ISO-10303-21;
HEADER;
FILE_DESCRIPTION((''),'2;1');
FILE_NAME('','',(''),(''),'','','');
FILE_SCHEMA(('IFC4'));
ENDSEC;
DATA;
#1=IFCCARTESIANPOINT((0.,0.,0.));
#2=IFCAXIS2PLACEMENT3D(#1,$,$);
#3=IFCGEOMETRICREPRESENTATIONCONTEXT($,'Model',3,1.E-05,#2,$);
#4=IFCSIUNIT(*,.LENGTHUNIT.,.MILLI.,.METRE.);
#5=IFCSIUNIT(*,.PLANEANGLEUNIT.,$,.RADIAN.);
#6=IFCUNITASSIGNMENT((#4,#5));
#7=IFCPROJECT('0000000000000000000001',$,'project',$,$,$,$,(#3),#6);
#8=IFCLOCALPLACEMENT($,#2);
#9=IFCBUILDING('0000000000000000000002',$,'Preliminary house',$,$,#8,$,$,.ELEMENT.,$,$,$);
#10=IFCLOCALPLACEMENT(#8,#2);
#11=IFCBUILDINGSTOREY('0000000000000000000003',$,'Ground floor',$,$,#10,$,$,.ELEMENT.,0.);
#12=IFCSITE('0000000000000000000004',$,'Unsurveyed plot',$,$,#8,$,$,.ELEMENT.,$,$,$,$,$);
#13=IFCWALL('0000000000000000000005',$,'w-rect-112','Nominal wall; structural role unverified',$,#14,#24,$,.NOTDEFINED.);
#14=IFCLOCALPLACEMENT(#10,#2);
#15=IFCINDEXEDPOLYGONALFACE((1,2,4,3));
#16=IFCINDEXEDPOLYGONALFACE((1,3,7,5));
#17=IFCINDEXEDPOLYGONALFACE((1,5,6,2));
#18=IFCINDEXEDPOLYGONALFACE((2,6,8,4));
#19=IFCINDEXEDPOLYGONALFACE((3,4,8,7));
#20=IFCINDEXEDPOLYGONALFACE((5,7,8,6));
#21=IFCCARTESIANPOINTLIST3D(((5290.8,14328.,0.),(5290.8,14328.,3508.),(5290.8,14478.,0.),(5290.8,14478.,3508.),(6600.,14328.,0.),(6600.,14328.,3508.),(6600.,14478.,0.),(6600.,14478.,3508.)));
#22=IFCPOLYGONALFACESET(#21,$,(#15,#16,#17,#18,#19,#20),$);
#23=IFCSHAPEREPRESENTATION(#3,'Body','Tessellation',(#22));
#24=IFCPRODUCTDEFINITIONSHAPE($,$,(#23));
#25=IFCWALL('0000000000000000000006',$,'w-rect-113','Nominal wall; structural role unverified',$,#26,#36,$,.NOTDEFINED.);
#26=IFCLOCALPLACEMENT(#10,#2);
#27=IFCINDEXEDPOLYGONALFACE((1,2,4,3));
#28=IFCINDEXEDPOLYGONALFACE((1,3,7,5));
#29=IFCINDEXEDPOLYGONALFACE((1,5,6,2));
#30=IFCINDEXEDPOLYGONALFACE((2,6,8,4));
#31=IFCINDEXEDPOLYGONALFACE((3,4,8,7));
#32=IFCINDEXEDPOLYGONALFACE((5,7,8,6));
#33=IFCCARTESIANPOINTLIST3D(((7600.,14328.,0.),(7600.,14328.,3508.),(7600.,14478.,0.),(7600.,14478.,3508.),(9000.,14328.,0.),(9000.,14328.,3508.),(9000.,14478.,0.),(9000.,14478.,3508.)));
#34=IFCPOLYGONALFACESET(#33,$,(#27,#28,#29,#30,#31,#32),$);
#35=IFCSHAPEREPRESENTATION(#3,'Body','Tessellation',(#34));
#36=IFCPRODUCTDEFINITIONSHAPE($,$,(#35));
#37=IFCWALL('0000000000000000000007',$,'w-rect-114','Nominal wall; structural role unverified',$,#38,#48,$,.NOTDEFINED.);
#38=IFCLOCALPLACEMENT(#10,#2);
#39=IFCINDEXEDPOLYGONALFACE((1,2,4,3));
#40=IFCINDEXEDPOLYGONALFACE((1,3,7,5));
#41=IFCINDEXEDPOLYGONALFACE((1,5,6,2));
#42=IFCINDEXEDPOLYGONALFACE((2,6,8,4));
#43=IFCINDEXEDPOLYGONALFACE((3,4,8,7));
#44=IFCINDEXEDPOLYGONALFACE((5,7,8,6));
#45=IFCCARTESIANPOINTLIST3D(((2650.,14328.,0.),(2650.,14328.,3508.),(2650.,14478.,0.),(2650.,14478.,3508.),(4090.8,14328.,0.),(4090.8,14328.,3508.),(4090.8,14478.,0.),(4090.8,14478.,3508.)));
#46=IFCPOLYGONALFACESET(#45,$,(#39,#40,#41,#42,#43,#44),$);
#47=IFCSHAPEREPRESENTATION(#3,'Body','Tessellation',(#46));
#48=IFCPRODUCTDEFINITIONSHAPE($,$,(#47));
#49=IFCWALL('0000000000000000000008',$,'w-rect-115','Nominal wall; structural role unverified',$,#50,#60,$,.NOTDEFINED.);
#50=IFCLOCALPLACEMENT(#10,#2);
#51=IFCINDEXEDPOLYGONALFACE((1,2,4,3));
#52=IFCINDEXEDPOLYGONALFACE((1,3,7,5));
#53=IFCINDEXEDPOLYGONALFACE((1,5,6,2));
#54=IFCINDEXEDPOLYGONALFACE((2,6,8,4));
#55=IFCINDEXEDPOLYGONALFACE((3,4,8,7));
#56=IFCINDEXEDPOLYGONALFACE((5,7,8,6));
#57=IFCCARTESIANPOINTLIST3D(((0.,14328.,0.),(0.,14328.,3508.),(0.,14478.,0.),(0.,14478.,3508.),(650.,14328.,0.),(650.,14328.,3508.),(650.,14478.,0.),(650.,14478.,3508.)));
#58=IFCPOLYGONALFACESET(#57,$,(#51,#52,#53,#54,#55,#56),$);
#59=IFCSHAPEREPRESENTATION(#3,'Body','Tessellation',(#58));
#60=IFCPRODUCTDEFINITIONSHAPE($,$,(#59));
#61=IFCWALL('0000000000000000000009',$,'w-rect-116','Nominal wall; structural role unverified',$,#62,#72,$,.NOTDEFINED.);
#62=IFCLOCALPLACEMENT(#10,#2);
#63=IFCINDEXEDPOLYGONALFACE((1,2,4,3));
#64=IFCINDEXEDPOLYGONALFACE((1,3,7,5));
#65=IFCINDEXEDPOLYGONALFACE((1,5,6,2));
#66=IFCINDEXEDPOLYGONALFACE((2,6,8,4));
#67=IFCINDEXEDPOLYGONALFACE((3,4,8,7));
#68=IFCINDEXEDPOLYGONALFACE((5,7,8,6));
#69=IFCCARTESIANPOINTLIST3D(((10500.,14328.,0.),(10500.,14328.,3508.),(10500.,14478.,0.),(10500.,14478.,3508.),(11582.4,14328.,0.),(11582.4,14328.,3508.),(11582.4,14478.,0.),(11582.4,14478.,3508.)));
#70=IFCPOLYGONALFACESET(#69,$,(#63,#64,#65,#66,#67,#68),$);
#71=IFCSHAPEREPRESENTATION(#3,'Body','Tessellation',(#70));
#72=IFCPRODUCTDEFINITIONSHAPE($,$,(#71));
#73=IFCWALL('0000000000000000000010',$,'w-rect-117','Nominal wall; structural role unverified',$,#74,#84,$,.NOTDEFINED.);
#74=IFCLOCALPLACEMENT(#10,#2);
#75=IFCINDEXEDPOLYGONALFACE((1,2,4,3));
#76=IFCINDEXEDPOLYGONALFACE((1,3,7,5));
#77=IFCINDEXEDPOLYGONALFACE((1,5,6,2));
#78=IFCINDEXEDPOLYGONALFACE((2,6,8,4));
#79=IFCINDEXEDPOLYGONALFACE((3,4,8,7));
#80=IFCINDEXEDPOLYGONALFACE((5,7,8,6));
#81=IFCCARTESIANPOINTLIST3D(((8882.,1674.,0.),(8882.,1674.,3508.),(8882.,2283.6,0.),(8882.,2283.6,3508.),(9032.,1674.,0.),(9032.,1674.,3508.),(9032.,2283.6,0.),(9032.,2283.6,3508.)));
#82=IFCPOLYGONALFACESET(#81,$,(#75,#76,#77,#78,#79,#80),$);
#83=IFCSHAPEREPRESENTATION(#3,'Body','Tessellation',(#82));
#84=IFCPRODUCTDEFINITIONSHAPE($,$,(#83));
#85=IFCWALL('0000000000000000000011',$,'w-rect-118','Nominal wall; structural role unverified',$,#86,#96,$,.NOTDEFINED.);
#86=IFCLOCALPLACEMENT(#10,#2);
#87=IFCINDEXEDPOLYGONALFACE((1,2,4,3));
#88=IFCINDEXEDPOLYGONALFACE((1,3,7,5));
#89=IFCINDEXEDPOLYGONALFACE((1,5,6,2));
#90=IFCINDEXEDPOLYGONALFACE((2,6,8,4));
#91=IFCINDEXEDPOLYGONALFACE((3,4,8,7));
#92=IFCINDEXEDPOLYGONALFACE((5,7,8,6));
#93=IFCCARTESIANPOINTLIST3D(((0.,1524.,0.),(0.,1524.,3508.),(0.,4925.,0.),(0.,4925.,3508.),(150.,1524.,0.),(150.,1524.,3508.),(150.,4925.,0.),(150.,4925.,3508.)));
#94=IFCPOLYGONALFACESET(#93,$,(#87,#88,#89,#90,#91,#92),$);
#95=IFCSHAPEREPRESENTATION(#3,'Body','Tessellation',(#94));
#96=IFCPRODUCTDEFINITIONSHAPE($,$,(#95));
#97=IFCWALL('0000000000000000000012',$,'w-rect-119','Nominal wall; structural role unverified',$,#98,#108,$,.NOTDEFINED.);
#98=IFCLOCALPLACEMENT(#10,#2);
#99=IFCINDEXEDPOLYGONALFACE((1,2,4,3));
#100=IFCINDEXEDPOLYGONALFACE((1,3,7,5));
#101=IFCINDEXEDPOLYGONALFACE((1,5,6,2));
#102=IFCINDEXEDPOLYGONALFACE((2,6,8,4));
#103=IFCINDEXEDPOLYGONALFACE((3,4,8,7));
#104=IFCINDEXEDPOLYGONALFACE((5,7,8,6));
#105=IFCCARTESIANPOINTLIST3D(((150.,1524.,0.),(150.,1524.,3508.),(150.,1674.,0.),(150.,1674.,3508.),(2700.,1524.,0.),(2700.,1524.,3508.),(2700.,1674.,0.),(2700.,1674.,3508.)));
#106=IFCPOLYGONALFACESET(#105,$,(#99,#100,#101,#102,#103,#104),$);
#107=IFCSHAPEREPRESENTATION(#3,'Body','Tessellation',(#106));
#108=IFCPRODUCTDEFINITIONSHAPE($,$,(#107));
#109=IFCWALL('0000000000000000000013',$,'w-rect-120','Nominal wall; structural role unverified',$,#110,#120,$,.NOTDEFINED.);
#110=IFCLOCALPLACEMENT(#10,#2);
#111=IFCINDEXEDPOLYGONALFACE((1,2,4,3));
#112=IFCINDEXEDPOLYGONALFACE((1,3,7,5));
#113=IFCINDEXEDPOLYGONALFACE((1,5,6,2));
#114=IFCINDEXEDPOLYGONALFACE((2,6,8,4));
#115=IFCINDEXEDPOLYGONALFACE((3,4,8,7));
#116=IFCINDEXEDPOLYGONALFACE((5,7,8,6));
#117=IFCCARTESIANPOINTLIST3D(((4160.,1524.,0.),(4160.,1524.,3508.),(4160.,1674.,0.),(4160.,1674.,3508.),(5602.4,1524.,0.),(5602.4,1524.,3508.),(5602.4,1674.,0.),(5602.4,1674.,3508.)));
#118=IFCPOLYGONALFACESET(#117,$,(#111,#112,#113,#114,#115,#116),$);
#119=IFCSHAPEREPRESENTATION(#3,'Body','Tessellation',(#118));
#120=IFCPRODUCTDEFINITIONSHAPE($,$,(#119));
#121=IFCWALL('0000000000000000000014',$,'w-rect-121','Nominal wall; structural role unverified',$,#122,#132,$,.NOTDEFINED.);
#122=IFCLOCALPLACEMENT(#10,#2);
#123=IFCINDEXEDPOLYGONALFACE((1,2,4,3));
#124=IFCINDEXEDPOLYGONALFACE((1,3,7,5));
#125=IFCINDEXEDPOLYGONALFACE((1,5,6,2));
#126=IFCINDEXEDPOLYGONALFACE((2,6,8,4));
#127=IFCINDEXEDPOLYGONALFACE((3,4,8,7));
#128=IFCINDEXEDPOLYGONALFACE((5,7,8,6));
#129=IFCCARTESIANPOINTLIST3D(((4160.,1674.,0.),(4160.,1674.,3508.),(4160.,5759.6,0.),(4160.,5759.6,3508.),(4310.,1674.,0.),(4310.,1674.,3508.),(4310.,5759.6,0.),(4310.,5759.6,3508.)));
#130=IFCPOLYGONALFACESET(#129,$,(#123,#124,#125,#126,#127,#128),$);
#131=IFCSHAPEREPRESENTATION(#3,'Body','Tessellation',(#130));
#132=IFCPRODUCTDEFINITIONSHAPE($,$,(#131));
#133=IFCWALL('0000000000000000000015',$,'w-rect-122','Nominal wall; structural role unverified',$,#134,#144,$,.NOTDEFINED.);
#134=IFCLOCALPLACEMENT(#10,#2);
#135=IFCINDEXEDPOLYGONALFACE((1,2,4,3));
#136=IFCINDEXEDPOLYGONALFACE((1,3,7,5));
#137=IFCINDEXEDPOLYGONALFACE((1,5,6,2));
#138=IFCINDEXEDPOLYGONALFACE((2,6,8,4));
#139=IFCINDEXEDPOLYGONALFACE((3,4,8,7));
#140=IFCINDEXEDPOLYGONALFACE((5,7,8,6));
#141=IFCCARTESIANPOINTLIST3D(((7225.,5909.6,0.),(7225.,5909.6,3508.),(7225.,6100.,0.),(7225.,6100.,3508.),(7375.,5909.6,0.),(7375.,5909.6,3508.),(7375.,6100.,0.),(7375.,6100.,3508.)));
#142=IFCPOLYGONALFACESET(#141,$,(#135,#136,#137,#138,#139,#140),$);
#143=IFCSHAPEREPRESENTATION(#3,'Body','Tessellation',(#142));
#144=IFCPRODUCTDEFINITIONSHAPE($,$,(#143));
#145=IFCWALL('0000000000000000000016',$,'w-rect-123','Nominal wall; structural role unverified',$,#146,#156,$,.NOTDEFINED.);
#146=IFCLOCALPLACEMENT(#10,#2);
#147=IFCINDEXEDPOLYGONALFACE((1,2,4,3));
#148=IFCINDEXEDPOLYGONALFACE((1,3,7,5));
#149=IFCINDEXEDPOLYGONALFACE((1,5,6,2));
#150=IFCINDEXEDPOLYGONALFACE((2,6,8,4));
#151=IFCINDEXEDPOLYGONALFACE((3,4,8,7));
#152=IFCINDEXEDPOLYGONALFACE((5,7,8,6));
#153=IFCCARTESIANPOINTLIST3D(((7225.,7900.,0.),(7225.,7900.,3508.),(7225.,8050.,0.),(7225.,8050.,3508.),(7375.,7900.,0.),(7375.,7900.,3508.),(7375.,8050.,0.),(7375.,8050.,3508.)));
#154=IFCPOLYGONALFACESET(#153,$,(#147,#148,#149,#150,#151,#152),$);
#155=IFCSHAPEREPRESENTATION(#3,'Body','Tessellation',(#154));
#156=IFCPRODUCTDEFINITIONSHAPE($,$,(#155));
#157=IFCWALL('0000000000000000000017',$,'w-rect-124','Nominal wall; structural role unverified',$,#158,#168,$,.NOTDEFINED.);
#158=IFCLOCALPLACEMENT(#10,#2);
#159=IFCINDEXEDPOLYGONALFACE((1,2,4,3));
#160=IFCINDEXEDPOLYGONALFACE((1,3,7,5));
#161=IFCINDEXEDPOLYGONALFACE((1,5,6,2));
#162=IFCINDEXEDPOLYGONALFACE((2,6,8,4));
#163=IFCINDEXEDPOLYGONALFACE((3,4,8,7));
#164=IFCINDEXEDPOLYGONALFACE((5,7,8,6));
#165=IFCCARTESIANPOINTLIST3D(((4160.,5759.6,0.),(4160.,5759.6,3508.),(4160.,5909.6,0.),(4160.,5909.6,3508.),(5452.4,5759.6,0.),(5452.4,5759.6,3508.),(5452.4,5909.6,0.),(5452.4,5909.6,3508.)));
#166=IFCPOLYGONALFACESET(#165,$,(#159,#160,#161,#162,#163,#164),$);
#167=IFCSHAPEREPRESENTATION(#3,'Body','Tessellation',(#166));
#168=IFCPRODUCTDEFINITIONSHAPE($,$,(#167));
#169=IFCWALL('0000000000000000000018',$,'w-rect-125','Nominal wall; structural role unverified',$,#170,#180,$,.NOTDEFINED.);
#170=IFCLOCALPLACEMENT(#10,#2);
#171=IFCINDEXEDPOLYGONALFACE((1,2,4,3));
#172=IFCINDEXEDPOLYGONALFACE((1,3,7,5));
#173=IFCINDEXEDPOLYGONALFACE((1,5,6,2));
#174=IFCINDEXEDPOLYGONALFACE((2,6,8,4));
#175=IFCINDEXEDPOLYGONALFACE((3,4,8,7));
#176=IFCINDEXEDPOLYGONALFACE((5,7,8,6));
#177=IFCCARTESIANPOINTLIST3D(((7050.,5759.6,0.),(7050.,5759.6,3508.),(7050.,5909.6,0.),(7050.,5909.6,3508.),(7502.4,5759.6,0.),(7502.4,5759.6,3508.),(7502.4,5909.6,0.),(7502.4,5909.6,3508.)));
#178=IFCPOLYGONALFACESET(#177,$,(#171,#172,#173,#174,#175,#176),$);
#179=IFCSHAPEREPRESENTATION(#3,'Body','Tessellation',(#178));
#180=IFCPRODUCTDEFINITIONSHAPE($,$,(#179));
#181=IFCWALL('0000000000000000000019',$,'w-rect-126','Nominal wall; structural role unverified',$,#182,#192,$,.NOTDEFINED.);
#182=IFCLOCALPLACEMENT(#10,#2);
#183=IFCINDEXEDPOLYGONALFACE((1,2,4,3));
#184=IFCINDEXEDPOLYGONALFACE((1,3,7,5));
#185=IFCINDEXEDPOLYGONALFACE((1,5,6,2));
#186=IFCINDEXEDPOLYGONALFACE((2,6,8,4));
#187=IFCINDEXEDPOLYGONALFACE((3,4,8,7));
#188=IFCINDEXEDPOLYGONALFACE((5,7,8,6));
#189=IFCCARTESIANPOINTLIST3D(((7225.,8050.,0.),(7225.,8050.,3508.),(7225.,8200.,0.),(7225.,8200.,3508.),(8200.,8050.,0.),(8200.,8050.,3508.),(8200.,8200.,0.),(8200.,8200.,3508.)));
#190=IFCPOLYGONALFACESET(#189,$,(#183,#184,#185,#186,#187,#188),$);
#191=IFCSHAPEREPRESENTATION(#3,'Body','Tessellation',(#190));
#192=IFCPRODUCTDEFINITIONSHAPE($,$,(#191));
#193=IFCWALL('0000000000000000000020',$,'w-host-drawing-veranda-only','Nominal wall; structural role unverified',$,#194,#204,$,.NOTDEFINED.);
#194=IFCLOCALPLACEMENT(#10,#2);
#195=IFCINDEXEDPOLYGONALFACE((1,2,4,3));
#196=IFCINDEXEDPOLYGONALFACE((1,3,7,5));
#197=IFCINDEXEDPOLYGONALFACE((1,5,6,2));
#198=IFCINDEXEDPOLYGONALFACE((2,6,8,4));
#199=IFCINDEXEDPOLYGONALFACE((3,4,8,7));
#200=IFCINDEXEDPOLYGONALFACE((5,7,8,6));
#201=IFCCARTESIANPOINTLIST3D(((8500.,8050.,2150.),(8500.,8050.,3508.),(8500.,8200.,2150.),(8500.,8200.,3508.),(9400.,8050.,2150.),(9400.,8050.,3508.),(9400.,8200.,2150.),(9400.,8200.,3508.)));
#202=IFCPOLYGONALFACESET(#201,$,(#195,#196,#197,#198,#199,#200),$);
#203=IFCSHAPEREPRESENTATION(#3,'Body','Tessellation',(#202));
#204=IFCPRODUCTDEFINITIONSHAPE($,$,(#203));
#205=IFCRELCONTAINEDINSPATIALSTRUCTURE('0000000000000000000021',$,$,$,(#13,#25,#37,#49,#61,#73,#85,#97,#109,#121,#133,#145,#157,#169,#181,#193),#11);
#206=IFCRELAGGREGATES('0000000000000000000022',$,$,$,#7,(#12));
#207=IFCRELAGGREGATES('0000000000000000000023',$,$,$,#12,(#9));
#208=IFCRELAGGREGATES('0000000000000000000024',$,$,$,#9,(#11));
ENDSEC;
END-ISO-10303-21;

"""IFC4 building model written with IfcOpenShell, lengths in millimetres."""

from ifc_helpers import new_model, si_unit, origin, place, context, project, spatial, polyline, outline, extrude, element, save


model = new_model("IFC4")

# Units and contexts
model_context = context("Model", 3, precision=1e-05, world=origin())
ifc_project = project(units=[si_unit("LENGTHUNIT", "METRE", prefix="MILLI"), si_unit("PLANEANGLEUNIT", "RADIAN")], contexts=[model_context])

# Site, building, storey
placement_1 = place(None, origin())
site = spatial("IfcSite", under=ifc_project, at=placement_1, Name="Unsurveyed plot", CompositionType="ELEMENT")
building = spatial("IfcBuilding", under=site, at=placement_1, Name="Preliminary house", CompositionType="ELEMENT")
placement_2 = place(placement_1, origin())
storey = spatial("IfcBuildingStorey", under=building, at=placement_2, Name="Ground floor", CompositionType="ELEMENT", Elevation=0.0)

# Walls
element("IfcWall", 1, at=placement_2, inside=storey, Name="w-rect-112", Description="Nominal wall; structural role unverified", PredefinedType="NOTDEFINED", context=model_context, shape_type="SweptSolid", body=[
    extrude(outline(polyline([(5290.8, 14328.0), (6600.0, 14328.0), (6600.0, 14478.0), (5290.8, 14478.0), (5290.8, 14328.0)])), origin(), (0.0, 0.0, 1.0), 3508.0),
])
element("IfcWall", 2, at=placement_2, inside=storey, Name="w-rect-113", Description="Nominal wall; structural role unverified", PredefinedType="NOTDEFINED", context=model_context, shape_type="SweptSolid", body=[
    extrude(outline(polyline([(7600.0, 14328.0), (9000.0, 14328.0), (9000.0, 14478.0), (7600.0, 14478.0), (7600.0, 14328.0)])), origin(), (0.0, 0.0, 1.0), 3508.0),
])
element("IfcWall", 3, at=placement_2, inside=storey, Name="w-rect-114", Description="Nominal wall; structural role unverified", PredefinedType="NOTDEFINED", context=model_context, shape_type="SweptSolid", body=[
    extrude(outline(polyline([(2650.0, 14328.0), (4090.8, 14328.0), (4090.8, 14478.0), (2650.0, 14478.0), (2650.0, 14328.0)])), origin(), (0.0, 0.0, 1.0), 3508.0),
])
element("IfcWall", 4, at=placement_2, inside=storey, Name="w-rect-115", Description="Nominal wall; structural role unverified", PredefinedType="NOTDEFINED", context=model_context, shape_type="SweptSolid", body=[
    extrude(outline(polyline([(0.0, 14328.0), (650.0, 14328.0), (650.0, 14478.0), (0.0, 14478.0), (0.0, 14328.0)])), origin(), (0.0, 0.0, 1.0), 3508.0),
])
element("IfcWall", 5, at=placement_2, inside=storey, Name="w-rect-116", Description="Nominal wall; structural role unverified", PredefinedType="NOTDEFINED", context=model_context, shape_type="SweptSolid", body=[
    extrude(outline(polyline([(10500.0, 14328.0), (11582.4, 14328.0), (11582.4, 14478.0), (10500.0, 14478.0), (10500.0, 14328.0)])), origin(), (0.0, 0.0, 1.0), 3508.0),
])
element("IfcWall", 6, at=placement_2, inside=storey, Name="w-rect-117", Description="Nominal wall; structural role unverified", PredefinedType="NOTDEFINED", context=model_context, shape_type="SweptSolid", body=[
    extrude(outline(polyline([(8882.0, 1674.0), (9032.0, 1674.0), (9032.0, 2283.6), (8882.0, 2283.6), (8882.0, 1674.0)])), origin(), (0.0, 0.0, 1.0), 3508.0),
])
element("IfcWall", 7, at=placement_2, inside=storey, Name="w-rect-118", Description="Nominal wall; structural role unverified", PredefinedType="NOTDEFINED", context=model_context, shape_type="SweptSolid", body=[
    extrude(outline(polyline([(0.0, 1524.0), (150.0, 1524.0), (150.0, 4925.0), (0.0, 4925.0), (0.0, 1524.0)])), origin(), (0.0, 0.0, 1.0), 3508.0),
])
element("IfcWall", 8, at=placement_2, inside=storey, Name="w-rect-119", Description="Nominal wall; structural role unverified", PredefinedType="NOTDEFINED", context=model_context, shape_type="SweptSolid", body=[
    extrude(outline(polyline([(150.0, 1524.0), (2700.0, 1524.0), (2700.0, 1674.0), (150.0, 1674.0), (150.0, 1524.0)])), origin(), (0.0, 0.0, 1.0), 3508.0),
])
element("IfcWall", 9, at=placement_2, inside=storey, Name="w-rect-120", Description="Nominal wall; structural role unverified", PredefinedType="NOTDEFINED", context=model_context, shape_type="SweptSolid", body=[
    extrude(outline(polyline([(4160.0, 1524.0), (5602.4, 1524.0), (5602.4, 1674.0), (4160.0, 1674.0), (4160.0, 1524.0)])), origin(), (0.0, 0.0, 1.0), 3508.0),
])
element("IfcWall", 10, at=placement_2, inside=storey, Name="w-rect-121", Description="Nominal wall; structural role unverified", PredefinedType="NOTDEFINED", context=model_context, shape_type="SweptSolid", body=[
    extrude(outline(polyline([(4160.0, 1674.0), (4310.0, 1674.0), (4310.0, 5759.6), (4160.0, 5759.6), (4160.0, 1674.0)])), origin(), (0.0, 0.0, 1.0), 3508.0),
])
element("IfcWall", 11, at=placement_2, inside=storey, Name="w-rect-122", Description="Nominal wall; structural role unverified", PredefinedType="NOTDEFINED", context=model_context, shape_type="SweptSolid", body=[
    extrude(outline(polyline([(7225.0, 5909.6), (7375.0, 5909.6), (7375.0, 6100.0), (7225.0, 6100.0), (7225.0, 5909.6)])), origin(), (0.0, 0.0, 1.0), 3508.0),
])
element("IfcWall", 12, at=placement_2, inside=storey, Name="w-rect-123", Description="Nominal wall; structural role unverified", PredefinedType="NOTDEFINED", context=model_context, shape_type="SweptSolid", body=[
    extrude(outline(polyline([(7225.0, 7900.0), (7375.0, 7900.0), (7375.0, 8050.0), (7225.0, 8050.0), (7225.0, 7900.0)])), origin(), (0.0, 0.0, 1.0), 3508.0),
])
element("IfcWall", 13, at=placement_2, inside=storey, Name="w-rect-124", Description="Nominal wall; structural role unverified", PredefinedType="NOTDEFINED", context=model_context, shape_type="SweptSolid", body=[
    extrude(outline(polyline([(4160.0, 5759.6), (5452.4, 5759.6), (5452.4, 5909.6), (4160.0, 5909.6), (4160.0, 5759.6)])), origin(), (0.0, 0.0, 1.0), 3508.0),
])
element("IfcWall", 14, at=placement_2, inside=storey, Name="w-rect-125", Description="Nominal wall; structural role unverified", PredefinedType="NOTDEFINED", context=model_context, shape_type="SweptSolid", body=[
    extrude(outline(polyline([(7050.0, 5759.6), (7502.4, 5759.6), (7502.4, 5909.6), (7050.0, 5909.6), (7050.0, 5759.6)])), origin(), (0.0, 0.0, 1.0), 3508.0),
])
element("IfcWall", 15, at=placement_2, inside=storey, Name="w-rect-126", Description="Nominal wall; structural role unverified", PredefinedType="NOTDEFINED", context=model_context, shape_type="SweptSolid", body=[
    extrude(outline(polyline([(7225.0, 8050.0), (8200.0, 8050.0), (8200.0, 8200.0), (7225.0, 8200.0), (7225.0, 8050.0)])), origin(), (0.0, 0.0, 1.0), 3508.0),
])

# Wall, opening
wall_1 = element("IfcWall", 16, at=placement_2, inside=storey, Name="w-host-drawing-veranda-only", Description="Nominal wall; structural role unverified", PredefinedType="NOTDEFINED", context=model_context, shape_type="SweptSolid", body=[
    extrude(outline(polyline([(8500.0, 8050.0), (9400.0, 8050.0), (9400.0, 8200.0), (8500.0, 8200.0), (8500.0, 8050.0)])), origin(), (0.0, 0.0, 1.0), 3508.0),
])
element("IfcOpeningElement", 17, at=placement_2, cuts=wall_1, PredefinedType="OPENING", context=model_context, shape_type="SweptSolid", body=[
    extrude(outline(polyline([(8500.0, 7675.0), (9400.0, 7675.0), (9400.0, 8575.0), (8500.0, 8575.0), (8500.0, 7675.0)])), origin(), (0.0, 0.0, 1.0), 2150.0),
])

save(model, "model.ifc")
